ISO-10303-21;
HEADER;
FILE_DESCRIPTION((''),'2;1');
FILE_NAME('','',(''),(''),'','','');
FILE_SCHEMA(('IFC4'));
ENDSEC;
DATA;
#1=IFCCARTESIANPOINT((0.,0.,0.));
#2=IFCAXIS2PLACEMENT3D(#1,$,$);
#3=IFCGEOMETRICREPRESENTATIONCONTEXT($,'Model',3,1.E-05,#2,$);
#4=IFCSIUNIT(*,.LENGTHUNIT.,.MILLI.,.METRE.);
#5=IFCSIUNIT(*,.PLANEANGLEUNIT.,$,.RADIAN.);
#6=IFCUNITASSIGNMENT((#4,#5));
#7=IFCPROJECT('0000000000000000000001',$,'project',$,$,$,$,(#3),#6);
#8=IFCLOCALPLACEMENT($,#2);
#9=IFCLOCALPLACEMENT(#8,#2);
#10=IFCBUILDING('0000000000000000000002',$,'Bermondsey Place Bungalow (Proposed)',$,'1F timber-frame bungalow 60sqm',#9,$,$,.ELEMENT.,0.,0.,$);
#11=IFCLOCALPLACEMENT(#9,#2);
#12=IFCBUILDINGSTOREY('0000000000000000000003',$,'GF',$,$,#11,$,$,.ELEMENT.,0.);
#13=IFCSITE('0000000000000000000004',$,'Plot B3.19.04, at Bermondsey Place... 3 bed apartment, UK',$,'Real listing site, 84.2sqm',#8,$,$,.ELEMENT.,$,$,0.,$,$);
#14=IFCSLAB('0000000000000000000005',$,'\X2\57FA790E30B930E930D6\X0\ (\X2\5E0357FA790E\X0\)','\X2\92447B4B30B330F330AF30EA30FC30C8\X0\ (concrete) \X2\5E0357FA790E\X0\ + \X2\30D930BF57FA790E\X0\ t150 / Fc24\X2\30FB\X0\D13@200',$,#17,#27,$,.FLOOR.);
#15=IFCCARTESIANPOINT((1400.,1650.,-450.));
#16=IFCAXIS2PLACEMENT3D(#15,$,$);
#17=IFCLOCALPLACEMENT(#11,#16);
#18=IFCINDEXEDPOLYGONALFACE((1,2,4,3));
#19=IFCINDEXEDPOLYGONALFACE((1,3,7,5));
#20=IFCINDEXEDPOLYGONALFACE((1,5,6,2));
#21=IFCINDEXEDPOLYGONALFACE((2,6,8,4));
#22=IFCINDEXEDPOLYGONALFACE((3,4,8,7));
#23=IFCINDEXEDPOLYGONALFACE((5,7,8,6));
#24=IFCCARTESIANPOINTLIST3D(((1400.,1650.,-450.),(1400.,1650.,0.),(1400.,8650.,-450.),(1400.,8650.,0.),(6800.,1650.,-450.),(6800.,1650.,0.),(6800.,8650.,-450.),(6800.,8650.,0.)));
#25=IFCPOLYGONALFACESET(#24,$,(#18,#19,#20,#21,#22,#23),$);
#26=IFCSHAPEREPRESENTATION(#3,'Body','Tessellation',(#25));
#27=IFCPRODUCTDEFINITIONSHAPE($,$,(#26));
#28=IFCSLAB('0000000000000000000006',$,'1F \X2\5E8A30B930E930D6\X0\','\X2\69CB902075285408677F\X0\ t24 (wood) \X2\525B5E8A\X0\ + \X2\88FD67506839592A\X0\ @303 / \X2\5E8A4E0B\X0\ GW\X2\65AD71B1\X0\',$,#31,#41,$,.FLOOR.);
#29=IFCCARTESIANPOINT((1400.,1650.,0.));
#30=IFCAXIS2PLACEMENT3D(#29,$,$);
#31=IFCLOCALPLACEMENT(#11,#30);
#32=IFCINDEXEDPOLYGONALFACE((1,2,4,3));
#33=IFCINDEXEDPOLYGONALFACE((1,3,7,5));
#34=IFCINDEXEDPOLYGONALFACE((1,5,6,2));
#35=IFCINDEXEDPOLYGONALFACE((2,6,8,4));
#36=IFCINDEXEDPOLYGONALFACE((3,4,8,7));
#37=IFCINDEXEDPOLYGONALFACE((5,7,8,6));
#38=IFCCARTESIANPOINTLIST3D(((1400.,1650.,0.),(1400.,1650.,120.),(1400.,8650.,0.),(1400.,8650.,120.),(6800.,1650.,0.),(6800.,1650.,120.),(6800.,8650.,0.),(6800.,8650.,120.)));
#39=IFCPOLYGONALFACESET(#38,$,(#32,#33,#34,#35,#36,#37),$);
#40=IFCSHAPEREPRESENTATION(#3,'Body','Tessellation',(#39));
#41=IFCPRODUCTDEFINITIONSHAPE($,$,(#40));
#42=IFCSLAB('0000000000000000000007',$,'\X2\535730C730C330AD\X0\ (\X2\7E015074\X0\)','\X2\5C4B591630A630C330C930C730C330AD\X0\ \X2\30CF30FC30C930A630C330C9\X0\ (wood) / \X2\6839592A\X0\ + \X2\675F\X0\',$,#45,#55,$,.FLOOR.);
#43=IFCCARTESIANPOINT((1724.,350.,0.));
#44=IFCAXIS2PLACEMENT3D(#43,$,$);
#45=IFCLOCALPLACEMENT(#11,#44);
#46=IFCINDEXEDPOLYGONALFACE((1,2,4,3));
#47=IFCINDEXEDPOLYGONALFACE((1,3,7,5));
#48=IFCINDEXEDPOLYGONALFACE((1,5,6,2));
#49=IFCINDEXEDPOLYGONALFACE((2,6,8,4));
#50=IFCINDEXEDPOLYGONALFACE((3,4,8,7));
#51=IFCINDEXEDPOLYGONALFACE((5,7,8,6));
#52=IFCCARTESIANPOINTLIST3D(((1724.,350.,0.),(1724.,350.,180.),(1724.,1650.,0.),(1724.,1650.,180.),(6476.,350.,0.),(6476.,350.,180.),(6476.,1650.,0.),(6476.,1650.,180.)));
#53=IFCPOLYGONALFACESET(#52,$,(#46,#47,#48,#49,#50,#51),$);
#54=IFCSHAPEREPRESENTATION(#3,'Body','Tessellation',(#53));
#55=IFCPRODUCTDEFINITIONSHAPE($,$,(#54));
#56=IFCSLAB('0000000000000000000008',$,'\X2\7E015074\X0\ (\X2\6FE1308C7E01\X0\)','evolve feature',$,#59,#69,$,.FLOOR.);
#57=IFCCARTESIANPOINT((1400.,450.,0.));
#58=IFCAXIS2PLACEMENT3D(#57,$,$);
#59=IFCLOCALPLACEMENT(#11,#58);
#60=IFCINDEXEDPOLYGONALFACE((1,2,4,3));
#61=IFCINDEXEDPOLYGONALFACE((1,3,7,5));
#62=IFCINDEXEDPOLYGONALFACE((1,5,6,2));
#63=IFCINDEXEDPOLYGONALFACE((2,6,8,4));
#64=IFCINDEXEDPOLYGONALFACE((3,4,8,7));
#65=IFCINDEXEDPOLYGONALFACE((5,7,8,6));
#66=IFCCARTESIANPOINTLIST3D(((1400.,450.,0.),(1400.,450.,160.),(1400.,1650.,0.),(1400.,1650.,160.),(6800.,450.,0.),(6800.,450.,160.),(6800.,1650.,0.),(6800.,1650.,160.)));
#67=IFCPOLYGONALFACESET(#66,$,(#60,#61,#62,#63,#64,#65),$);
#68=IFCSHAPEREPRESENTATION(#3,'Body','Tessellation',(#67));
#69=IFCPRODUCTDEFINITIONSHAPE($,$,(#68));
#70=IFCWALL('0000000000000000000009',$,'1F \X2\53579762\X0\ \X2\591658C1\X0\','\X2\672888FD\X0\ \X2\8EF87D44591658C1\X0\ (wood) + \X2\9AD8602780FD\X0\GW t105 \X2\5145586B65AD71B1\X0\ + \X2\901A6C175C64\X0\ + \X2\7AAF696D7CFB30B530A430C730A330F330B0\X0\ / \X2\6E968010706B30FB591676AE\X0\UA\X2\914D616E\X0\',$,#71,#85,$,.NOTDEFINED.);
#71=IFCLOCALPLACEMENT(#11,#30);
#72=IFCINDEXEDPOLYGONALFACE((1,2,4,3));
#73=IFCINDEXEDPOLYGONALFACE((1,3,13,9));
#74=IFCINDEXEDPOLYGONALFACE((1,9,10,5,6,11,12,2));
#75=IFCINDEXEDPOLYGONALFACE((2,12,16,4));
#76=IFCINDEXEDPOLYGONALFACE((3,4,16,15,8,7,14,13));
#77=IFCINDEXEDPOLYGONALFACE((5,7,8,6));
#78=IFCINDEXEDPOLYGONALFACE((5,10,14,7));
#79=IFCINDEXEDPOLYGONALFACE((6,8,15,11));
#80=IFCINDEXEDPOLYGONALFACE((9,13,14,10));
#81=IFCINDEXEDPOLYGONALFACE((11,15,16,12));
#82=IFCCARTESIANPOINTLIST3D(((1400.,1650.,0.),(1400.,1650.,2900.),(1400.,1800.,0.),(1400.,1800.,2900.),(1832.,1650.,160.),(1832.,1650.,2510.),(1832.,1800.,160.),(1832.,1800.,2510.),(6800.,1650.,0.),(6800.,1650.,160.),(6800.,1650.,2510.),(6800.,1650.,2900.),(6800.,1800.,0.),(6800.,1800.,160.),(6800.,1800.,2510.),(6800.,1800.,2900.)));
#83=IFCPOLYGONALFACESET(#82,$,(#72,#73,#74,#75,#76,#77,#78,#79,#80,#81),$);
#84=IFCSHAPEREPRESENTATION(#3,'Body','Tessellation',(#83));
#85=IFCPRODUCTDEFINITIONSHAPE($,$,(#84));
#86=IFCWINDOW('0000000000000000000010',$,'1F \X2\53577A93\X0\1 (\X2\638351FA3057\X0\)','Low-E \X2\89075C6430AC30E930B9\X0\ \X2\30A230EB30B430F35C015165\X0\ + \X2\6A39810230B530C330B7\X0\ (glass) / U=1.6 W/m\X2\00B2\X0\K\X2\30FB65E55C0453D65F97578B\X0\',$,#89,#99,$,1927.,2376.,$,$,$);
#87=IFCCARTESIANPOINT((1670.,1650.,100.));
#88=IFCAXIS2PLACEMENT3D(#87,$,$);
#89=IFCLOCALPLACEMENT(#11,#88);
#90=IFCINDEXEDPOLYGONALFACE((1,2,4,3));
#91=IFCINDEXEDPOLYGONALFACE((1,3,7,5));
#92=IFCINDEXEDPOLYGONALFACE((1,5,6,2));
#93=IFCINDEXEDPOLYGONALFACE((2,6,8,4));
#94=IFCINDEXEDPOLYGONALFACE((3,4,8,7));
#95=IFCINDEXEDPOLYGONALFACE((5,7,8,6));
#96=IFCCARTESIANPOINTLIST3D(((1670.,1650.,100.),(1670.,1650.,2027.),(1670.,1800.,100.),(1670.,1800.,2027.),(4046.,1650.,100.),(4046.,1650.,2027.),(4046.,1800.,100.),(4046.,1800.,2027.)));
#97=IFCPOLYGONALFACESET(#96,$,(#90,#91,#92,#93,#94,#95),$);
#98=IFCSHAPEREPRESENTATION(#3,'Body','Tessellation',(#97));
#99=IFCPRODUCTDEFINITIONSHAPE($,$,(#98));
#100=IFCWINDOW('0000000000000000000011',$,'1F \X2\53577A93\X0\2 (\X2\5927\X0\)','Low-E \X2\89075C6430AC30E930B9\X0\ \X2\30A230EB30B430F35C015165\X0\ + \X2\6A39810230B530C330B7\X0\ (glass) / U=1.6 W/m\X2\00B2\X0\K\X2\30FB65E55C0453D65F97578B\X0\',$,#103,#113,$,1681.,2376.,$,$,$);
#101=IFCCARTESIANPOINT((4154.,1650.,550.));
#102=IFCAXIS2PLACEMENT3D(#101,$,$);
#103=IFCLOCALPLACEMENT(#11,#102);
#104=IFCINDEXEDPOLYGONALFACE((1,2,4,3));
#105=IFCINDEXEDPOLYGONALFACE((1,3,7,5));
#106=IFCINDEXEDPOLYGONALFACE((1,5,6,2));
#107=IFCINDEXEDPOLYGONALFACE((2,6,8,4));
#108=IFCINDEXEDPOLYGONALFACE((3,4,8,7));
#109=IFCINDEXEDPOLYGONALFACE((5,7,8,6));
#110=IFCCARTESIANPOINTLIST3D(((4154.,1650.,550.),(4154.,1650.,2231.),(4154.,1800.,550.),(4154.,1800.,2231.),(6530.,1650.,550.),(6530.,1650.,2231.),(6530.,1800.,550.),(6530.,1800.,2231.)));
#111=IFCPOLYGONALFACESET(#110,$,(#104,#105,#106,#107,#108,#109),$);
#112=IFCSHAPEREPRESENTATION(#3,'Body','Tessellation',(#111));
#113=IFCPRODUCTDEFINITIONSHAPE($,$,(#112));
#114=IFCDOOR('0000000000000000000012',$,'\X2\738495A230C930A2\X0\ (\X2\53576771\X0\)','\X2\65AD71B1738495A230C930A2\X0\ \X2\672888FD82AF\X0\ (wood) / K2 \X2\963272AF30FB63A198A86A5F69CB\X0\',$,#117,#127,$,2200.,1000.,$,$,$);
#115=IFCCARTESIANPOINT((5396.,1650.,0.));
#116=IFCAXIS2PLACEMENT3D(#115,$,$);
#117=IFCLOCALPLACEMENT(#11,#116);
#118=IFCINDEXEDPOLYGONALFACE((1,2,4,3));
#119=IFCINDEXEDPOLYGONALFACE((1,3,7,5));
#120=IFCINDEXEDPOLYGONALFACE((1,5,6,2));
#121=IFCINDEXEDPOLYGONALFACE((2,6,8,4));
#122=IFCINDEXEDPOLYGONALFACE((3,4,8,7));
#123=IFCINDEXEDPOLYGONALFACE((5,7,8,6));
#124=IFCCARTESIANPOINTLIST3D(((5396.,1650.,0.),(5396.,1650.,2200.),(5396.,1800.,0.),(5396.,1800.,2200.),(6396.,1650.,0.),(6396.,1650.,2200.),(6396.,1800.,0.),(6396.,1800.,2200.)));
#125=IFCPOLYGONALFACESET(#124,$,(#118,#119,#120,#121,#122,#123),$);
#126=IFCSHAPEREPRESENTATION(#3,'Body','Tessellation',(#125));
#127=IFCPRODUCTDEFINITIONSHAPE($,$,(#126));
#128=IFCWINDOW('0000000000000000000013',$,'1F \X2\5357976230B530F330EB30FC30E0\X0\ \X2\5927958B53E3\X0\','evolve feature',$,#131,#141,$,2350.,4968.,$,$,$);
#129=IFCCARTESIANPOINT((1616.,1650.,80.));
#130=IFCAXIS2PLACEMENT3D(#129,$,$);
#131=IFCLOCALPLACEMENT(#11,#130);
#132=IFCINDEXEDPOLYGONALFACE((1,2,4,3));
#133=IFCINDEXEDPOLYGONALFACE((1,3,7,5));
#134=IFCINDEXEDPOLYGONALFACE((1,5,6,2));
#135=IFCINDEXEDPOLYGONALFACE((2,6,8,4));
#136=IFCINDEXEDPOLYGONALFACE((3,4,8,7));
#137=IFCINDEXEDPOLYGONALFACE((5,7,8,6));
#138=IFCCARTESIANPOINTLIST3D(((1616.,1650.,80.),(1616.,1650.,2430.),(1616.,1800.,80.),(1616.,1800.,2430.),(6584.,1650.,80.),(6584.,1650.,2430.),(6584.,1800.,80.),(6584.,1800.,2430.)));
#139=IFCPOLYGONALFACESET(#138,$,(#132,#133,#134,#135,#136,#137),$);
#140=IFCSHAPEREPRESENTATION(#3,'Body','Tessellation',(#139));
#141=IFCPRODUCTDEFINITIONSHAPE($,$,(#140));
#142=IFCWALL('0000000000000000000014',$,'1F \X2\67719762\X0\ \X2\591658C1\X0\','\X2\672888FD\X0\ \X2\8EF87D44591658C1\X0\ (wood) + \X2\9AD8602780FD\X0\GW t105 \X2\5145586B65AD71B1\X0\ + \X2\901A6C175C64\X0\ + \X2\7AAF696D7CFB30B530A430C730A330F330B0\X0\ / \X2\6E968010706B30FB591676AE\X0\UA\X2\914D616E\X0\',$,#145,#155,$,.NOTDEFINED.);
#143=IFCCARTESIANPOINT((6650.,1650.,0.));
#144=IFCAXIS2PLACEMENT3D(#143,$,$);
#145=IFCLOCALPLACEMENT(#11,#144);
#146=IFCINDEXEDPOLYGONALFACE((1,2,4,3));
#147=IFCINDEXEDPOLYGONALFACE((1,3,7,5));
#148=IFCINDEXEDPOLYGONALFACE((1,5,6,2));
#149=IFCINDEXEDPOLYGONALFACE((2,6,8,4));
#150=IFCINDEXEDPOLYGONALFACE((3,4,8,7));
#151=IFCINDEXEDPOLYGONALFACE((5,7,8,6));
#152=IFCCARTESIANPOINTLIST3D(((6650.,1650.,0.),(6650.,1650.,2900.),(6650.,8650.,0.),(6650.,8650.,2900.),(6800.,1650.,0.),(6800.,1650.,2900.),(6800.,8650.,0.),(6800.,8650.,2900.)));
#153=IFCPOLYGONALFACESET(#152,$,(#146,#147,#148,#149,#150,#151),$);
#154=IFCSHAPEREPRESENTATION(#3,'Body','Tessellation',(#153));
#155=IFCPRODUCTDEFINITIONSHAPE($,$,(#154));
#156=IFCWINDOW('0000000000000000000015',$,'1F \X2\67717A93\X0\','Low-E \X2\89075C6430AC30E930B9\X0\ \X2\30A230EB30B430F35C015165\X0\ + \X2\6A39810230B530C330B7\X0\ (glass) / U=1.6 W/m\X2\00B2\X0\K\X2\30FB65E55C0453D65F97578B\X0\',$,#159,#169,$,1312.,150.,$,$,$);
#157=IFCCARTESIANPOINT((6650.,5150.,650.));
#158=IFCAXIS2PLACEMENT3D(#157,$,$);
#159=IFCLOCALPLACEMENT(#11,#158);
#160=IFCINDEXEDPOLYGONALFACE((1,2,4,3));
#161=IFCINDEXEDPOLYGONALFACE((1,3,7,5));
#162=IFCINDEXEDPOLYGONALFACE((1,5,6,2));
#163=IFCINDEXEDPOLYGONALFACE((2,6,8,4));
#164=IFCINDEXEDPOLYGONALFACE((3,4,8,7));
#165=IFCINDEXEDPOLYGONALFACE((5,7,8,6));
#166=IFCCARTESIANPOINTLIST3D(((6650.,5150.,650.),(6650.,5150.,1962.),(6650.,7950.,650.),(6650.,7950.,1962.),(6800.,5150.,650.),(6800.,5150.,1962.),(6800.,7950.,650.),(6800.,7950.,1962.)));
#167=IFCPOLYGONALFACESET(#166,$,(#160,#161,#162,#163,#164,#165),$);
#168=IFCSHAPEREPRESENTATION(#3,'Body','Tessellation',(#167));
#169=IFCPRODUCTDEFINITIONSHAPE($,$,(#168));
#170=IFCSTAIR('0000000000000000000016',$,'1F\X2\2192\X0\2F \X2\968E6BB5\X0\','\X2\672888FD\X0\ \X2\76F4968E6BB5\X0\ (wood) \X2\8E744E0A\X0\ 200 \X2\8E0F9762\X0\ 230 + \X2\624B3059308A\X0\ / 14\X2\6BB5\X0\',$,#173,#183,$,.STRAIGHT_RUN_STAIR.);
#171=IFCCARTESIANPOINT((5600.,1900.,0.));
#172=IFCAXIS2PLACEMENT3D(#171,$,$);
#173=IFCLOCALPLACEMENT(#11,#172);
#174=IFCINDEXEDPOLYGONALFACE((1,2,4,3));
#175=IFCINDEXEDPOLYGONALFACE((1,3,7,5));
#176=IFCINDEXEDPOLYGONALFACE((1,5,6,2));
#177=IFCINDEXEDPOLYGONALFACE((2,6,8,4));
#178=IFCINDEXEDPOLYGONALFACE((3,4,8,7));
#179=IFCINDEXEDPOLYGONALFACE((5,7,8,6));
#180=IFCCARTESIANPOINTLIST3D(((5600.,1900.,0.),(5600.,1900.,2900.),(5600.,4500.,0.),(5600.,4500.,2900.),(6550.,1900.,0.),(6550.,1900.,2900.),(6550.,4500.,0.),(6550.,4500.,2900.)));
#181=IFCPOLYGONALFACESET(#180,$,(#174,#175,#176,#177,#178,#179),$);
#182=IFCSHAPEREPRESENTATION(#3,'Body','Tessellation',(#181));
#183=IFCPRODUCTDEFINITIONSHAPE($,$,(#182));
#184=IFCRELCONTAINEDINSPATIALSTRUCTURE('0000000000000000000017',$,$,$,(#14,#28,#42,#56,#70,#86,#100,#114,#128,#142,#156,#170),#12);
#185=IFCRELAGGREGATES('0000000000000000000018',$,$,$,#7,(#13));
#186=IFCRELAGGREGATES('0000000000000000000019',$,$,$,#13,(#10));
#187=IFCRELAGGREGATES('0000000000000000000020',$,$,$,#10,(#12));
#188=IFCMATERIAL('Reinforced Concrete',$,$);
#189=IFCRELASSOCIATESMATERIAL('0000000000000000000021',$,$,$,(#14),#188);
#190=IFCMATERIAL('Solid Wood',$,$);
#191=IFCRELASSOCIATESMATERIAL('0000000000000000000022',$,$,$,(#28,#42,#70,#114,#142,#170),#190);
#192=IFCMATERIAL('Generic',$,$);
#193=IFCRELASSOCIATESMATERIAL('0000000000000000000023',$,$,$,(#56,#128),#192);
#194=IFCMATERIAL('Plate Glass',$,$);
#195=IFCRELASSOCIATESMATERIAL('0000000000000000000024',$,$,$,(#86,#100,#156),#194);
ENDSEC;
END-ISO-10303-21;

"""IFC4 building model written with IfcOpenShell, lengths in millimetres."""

from ifc_helpers import new_model, si_unit, frame, frame_2d, origin, place, context, project, spatial, rectangle, extrude, material, element, fill, save


model = new_model("IFC4")

# Units and contexts
model_context = context("Model", 3, precision=1e-05, world=origin())
ifc_project = project(units=[si_unit("LENGTHUNIT", "METRE", prefix="MILLI"), si_unit("PLANEANGLEUNIT", "RADIAN")], contexts=[model_context])

# Site, building, storey
site_placement = place(None, origin())
site = spatial("IfcSite", under=ifc_project, at=site_placement, Name="Plot B3.19.04, at Bermondsey Place... 3 bed apartment, UK", ObjectType="Real listing site, 84.2sqm", CompositionType="ELEMENT", RefElevation=0.0)
building_placement = place(site_placement, origin())
building = spatial("IfcBuilding", under=site, at=building_placement, Name="Bermondsey Place Bungalow (Proposed)", ObjectType="1F timber-frame bungalow 60sqm", CompositionType="ELEMENT", ElevationOfRefHeight=0.0, ElevationOfTerrain=0.0)
storey_placement = place(building_placement, origin())
storey = spatial("IfcBuildingStorey", under=building, at=storey_placement, Name="GF", CompositionType="ELEMENT", Elevation=0.0)

# Slabs
ifc_material_1 = material(Name="Reinforced Concrete")
slab_1_placement = place(storey_placement, frame((1400.0, 1650.0, -450.0)))
element("IfcSlab", 1, at=slab_1_placement, inside=storey, material=ifc_material_1, Name="基礎スラブ (布基礎)", Description="鉄筋コンクリート (concrete) 布基礎 + ベタ基礎 t150 / Fc24・D13@200", PredefinedType="FLOOR", context=model_context, shape_type="SweptSolid", body=[
    extrude(rectangle(XDim=5400.0, YDim=7000.0, at=frame_2d((2700.0, 3500.0))), frame((1400.0, 1650.0, -450.0)), (0.0, 0.0, 1.0), 450.0),
])
ifc_material_2 = material(Name="Solid Wood")
slab_2_placement = place(storey_placement, frame((1400.0, 1650.0, 0.0)))
element("IfcSlab", 2, at=slab_2_placement, inside=storey, material=ifc_material_2, Name="1F 床スラブ", Description="構造用合板 t24 (wood) 剛床 + 製材根太 @303 / 床下 GW断熱", PredefinedType="FLOOR", context=model_context, shape_type="SweptSolid", body=[
    extrude(rectangle(XDim=5400.0, YDim=7000.0, at=frame_2d((2700.0, 3500.0))), frame((1400.0, 1650.0, 0.0)), (0.0, 0.0, 1.0), 120.0),
])
slab_3_placement = place(storey_placement, frame((1724.0, 350.0, 0.0)))
element("IfcSlab", 3, at=slab_3_placement, inside=storey, material=ifc_material_2, Name="南デッキ (縁側)", Description="屋外ウッドデッキ ハードウッド (wood) / 根太 + 束", PredefinedType="FLOOR", context=model_context, shape_type="SweptSolid", body=[
    extrude(rectangle(XDim=4752.0, YDim=1300.0, at=frame_2d((2376.0, 650.0))), frame((1724.0, 350.0, 0.0)), (0.0, 0.0, 1.0), 180.0),
])
ifc_material_3 = material(Name="Generic")
slab_4_placement = place(storey_placement, frame((1400.0, 450.0, 0.0)))
element("IfcSlab", 4, at=slab_4_placement, inside=storey, material=ifc_material_3, Name="縁側 (濡れ縁)", Description="evolve feature", PredefinedType="FLOOR", context=model_context, shape_type="SweptSolid", body=[
    extrude(rectangle(XDim=5400.0, YDim=1200.0, at=frame_2d((2700.0, 600.0))), frame((1400.0, 450.0, 0.0)), (0.0, 0.0, 1.0), 160.0),
])

# Wall, openings, windows, door
wall_1_placement = place(storey_placement, frame((1400.0, 1650.0, 0.0)))
wall_1 = element("IfcWall", 5, at=wall_1_placement, inside=storey, material=ifc_material_2, Name="1F 南面 外壁", Description="木製 軸組外壁 (wood) + 高性能GW t105 充填断熱 + 通気層 + 窯業系サイディング / 準耐火・外皮UA配慮", PredefinedType="NOTDEFINED", context=model_context, shape_type="SweptSolid", body=[
    extrude(rectangle(XDim=5400.0, YDim=150.0, at=frame_2d((2700.0, 75.0))), frame((1400.0, 1650.0, 0.0)), (0.0, 0.0, 1.0), 2900.0),
])
opening_1_placement = place(storey_placement, frame((1670.0, 1650.0, 100.0)))
opening_1 = element("IfcOpeningElement", 6, at=opening_1_placement, cuts=wall_1, PredefinedType="NOTDEFINED", context=model_context, shape_type="SweptSolid", body=[
    extrude(rectangle(XDim=2376.0, YDim=150.0, at=frame_2d((1188.0, 75.0))), frame((1670.0, 1650.0, 100.0)), (0.0, 0.0, 1.0), 1927.0),
])
opening_2_placement = place(storey_placement, frame((4154.0, 1650.0, 550.0)))
opening_2 = element("IfcOpeningElement", 7, at=opening_2_placement, cuts=wall_1, PredefinedType="NOTDEFINED", context=model_context, shape_type="SweptSolid", body=[
    extrude(rectangle(XDim=2376.0, YDim=150.0, at=frame_2d((1188.0, 75.0))), frame((4154.0, 1650.0, 550.0)), (0.0, 0.0, 1.0), 1681.0),
])
opening_3_placement = place(storey_placement, frame((5396.0, 1650.0, 0.0)))
opening_3 = element("IfcOpeningElement", 8, at=opening_3_placement, cuts=wall_1, PredefinedType="NOTDEFINED", context=model_context, shape_type="SweptSolid", body=[
    extrude(rectangle(XDim=1000.0, YDim=150.0, at=frame_2d((500.0, 75.0))), frame((5396.0, 1650.0, 0.0)), (0.0, 0.0, 1.0), 2200.0),
])
opening_4_placement = place(storey_placement, frame((1616.0, 1650.0, 80.0)))
opening_4 = element("IfcOpeningElement", 9, at=opening_4_placement, cuts=wall_1, PredefinedType="NOTDEFINED", context=model_context, shape_type="SweptSolid", body=[
    extrude(rectangle(XDim=4968.0, YDim=150.0, at=frame_2d((2484.0, 75.0))), frame((1616.0, 1650.0, 80.0)), (0.0, 0.0, 1.0), 2350.0),
])
ifc_material_4 = material(Name="Plate Glass")
window_1_placement = place(storey_placement, frame((1670.0, 1650.0, 100.0)))
window_1 = element("IfcWindow", 10, at=window_1_placement, inside=storey, material=ifc_material_4, Name="1F 南窓1 (掃出し)", Description="Low-E 複層ガラス アルゴン封入 + 樹脂サッシ (glass) / U=1.6 W/m²K・日射取得型", OverallHeight=1927.0, OverallWidth=2376.0, context=model_context, shape_type="SweptSolid", body=[
    extrude(rectangle(XDim=2376.0, YDim=150.0, at=frame_2d((1188.0, 75.0))), frame((1670.0, 1650.0, 100.0)), (0.0, 0.0, 1.0), 1927.0),
])
fill(opening_1, window_1)
window_2_placement = place(storey_placement, frame((4154.0, 1650.0, 550.0)))
window_2 = element("IfcWindow", 11, at=window_2_placement, inside=storey, material=ifc_material_4, Name="1F 南窓2 (大)", Description="Low-E 複層ガラス アルゴン封入 + 樹脂サッシ (glass) / U=1.6 W/m²K・日射取得型", OverallHeight=1681.0, OverallWidth=2376.0, context=model_context, shape_type="SweptSolid", body=[
    extrude(rectangle(XDim=2376.0, YDim=150.0, at=frame_2d((1188.0, 75.0))), frame((4154.0, 1650.0, 550.0)), (0.0, 0.0, 1.0), 1681.0),
])
fill(opening_2, window_2)
door_placement = place(storey_placement, frame((5396.0, 1650.0, 0.0)))
door = element("IfcDoor", 12, at=door_placement, inside=storey, material=ifc_material_2, Name="玄関ドア (南東)", Description="断熱玄関ドア 木製芯 (wood) / K2 防犯・採風機構", OverallHeight=2200.0, OverallWidth=1000.0, context=model_context, shape_type="SweptSolid", body=[
    extrude(rectangle(XDim=1000.0, YDim=150.0, at=frame_2d((500.0, 75.0))), frame((5396.0, 1650.0, 0.0)), (0.0, 0.0, 1.0), 2200.0),
])
fill(opening_3, door)
window_3_placement = place(storey_placement, frame((1616.0, 1650.0, 80.0)))
window_3 = element("IfcWindow", 13, at=window_3_placement, inside=storey, material=ifc_material_3, Name="1F 南面サンルーム 大開口", Description="evolve feature", OverallHeight=2350.0, OverallWidth=4968.0, context=model_context, shape_type="SweptSolid", body=[
    extrude(rectangle(XDim=4968.0, YDim=150.0, at=frame_2d((2484.0, 75.0))), frame((1616.0, 1650.0, 80.0)), (0.0, 0.0, 1.0), 2350.0),
])
fill(opening_4, window_3)

# Wall, opening, window
wall_2_placement = place(storey_placement, frame((6650.0, 1650.0, 0.0)))
wall_2 = element("IfcWall", 14, at=wall_2_placement, inside=storey, material=ifc_material_2, Name="1F 東面 外壁", Description="木製 軸組外壁 (wood) + 高性能GW t105 充填断熱 + 通気層 + 窯業系サイディング / 準耐火・外皮UA配慮", PredefinedType="NOTDEFINED", context=model_context, shape_type="SweptSolid", body=[
    extrude(rectangle(XDim=150.0, YDim=7000.0, at=frame_2d((75.0, 3500.0))), frame((6650.0, 1650.0, 0.0)), (0.0, 0.0, 1.0), 2900.0),
])
opening_5_placement = place(storey_placement, frame((6650.0, 5150.0, 650.0)))
opening_5 = element("IfcOpeningElement", 15, at=opening_5_placement, cuts=wall_2, PredefinedType="NOTDEFINED", context=model_context, shape_type="SweptSolid", body=[
    extrude(rectangle(XDim=150.0, YDim=2800.0, at=frame_2d((75.0, 1400.0))), frame((6650.0, 5150.0, 650.0)), (0.0, 0.0, 1.0), 1312.0),
])
window_4_placement = place(storey_placement, frame((6650.0, 5150.0, 650.0)))
window_4 = element("IfcWindow", 16, at=window_4_placement, inside=storey, material=ifc_material_4, Name="1F 東窓", Description="Low-E 複層ガラス アルゴン封入 + 樹脂サッシ (glass) / U=1.6 W/m²K・日射取得型", OverallHeight=1312.0, OverallWidth=150.0, context=model_context, shape_type="SweptSolid", body=[
    extrude(rectangle(XDim=150.0, YDim=2800.0, at=frame_2d((75.0, 1400.0))), frame((6650.0, 5150.0, 650.0)), (0.0, 0.0, 1.0), 1312.0),
])
fill(opening_5, window_4)

# Stair
stair_placement = place(storey_placement, frame((5600.0, 1900.0, 0.0)))
element("IfcStair", 17, at=stair_placement, inside=storey, material=ifc_material_2, Name="1F→2F 階段", Description="木製 直階段 (wood) 蹴上 200 踏面 230 + 手すり / 14段", PredefinedType="STRAIGHT_RUN_STAIR", context=model_context, shape_type="SweptSolid", body=[
    extrude(rectangle(XDim=950.0, YDim=2600.0, at=frame_2d((475.0, 1300.0))), frame((5600.0, 1900.0, 0.0)), (0.0, 0.0, 1.0), 2900.0),
])

save(model, "model.ifc")
